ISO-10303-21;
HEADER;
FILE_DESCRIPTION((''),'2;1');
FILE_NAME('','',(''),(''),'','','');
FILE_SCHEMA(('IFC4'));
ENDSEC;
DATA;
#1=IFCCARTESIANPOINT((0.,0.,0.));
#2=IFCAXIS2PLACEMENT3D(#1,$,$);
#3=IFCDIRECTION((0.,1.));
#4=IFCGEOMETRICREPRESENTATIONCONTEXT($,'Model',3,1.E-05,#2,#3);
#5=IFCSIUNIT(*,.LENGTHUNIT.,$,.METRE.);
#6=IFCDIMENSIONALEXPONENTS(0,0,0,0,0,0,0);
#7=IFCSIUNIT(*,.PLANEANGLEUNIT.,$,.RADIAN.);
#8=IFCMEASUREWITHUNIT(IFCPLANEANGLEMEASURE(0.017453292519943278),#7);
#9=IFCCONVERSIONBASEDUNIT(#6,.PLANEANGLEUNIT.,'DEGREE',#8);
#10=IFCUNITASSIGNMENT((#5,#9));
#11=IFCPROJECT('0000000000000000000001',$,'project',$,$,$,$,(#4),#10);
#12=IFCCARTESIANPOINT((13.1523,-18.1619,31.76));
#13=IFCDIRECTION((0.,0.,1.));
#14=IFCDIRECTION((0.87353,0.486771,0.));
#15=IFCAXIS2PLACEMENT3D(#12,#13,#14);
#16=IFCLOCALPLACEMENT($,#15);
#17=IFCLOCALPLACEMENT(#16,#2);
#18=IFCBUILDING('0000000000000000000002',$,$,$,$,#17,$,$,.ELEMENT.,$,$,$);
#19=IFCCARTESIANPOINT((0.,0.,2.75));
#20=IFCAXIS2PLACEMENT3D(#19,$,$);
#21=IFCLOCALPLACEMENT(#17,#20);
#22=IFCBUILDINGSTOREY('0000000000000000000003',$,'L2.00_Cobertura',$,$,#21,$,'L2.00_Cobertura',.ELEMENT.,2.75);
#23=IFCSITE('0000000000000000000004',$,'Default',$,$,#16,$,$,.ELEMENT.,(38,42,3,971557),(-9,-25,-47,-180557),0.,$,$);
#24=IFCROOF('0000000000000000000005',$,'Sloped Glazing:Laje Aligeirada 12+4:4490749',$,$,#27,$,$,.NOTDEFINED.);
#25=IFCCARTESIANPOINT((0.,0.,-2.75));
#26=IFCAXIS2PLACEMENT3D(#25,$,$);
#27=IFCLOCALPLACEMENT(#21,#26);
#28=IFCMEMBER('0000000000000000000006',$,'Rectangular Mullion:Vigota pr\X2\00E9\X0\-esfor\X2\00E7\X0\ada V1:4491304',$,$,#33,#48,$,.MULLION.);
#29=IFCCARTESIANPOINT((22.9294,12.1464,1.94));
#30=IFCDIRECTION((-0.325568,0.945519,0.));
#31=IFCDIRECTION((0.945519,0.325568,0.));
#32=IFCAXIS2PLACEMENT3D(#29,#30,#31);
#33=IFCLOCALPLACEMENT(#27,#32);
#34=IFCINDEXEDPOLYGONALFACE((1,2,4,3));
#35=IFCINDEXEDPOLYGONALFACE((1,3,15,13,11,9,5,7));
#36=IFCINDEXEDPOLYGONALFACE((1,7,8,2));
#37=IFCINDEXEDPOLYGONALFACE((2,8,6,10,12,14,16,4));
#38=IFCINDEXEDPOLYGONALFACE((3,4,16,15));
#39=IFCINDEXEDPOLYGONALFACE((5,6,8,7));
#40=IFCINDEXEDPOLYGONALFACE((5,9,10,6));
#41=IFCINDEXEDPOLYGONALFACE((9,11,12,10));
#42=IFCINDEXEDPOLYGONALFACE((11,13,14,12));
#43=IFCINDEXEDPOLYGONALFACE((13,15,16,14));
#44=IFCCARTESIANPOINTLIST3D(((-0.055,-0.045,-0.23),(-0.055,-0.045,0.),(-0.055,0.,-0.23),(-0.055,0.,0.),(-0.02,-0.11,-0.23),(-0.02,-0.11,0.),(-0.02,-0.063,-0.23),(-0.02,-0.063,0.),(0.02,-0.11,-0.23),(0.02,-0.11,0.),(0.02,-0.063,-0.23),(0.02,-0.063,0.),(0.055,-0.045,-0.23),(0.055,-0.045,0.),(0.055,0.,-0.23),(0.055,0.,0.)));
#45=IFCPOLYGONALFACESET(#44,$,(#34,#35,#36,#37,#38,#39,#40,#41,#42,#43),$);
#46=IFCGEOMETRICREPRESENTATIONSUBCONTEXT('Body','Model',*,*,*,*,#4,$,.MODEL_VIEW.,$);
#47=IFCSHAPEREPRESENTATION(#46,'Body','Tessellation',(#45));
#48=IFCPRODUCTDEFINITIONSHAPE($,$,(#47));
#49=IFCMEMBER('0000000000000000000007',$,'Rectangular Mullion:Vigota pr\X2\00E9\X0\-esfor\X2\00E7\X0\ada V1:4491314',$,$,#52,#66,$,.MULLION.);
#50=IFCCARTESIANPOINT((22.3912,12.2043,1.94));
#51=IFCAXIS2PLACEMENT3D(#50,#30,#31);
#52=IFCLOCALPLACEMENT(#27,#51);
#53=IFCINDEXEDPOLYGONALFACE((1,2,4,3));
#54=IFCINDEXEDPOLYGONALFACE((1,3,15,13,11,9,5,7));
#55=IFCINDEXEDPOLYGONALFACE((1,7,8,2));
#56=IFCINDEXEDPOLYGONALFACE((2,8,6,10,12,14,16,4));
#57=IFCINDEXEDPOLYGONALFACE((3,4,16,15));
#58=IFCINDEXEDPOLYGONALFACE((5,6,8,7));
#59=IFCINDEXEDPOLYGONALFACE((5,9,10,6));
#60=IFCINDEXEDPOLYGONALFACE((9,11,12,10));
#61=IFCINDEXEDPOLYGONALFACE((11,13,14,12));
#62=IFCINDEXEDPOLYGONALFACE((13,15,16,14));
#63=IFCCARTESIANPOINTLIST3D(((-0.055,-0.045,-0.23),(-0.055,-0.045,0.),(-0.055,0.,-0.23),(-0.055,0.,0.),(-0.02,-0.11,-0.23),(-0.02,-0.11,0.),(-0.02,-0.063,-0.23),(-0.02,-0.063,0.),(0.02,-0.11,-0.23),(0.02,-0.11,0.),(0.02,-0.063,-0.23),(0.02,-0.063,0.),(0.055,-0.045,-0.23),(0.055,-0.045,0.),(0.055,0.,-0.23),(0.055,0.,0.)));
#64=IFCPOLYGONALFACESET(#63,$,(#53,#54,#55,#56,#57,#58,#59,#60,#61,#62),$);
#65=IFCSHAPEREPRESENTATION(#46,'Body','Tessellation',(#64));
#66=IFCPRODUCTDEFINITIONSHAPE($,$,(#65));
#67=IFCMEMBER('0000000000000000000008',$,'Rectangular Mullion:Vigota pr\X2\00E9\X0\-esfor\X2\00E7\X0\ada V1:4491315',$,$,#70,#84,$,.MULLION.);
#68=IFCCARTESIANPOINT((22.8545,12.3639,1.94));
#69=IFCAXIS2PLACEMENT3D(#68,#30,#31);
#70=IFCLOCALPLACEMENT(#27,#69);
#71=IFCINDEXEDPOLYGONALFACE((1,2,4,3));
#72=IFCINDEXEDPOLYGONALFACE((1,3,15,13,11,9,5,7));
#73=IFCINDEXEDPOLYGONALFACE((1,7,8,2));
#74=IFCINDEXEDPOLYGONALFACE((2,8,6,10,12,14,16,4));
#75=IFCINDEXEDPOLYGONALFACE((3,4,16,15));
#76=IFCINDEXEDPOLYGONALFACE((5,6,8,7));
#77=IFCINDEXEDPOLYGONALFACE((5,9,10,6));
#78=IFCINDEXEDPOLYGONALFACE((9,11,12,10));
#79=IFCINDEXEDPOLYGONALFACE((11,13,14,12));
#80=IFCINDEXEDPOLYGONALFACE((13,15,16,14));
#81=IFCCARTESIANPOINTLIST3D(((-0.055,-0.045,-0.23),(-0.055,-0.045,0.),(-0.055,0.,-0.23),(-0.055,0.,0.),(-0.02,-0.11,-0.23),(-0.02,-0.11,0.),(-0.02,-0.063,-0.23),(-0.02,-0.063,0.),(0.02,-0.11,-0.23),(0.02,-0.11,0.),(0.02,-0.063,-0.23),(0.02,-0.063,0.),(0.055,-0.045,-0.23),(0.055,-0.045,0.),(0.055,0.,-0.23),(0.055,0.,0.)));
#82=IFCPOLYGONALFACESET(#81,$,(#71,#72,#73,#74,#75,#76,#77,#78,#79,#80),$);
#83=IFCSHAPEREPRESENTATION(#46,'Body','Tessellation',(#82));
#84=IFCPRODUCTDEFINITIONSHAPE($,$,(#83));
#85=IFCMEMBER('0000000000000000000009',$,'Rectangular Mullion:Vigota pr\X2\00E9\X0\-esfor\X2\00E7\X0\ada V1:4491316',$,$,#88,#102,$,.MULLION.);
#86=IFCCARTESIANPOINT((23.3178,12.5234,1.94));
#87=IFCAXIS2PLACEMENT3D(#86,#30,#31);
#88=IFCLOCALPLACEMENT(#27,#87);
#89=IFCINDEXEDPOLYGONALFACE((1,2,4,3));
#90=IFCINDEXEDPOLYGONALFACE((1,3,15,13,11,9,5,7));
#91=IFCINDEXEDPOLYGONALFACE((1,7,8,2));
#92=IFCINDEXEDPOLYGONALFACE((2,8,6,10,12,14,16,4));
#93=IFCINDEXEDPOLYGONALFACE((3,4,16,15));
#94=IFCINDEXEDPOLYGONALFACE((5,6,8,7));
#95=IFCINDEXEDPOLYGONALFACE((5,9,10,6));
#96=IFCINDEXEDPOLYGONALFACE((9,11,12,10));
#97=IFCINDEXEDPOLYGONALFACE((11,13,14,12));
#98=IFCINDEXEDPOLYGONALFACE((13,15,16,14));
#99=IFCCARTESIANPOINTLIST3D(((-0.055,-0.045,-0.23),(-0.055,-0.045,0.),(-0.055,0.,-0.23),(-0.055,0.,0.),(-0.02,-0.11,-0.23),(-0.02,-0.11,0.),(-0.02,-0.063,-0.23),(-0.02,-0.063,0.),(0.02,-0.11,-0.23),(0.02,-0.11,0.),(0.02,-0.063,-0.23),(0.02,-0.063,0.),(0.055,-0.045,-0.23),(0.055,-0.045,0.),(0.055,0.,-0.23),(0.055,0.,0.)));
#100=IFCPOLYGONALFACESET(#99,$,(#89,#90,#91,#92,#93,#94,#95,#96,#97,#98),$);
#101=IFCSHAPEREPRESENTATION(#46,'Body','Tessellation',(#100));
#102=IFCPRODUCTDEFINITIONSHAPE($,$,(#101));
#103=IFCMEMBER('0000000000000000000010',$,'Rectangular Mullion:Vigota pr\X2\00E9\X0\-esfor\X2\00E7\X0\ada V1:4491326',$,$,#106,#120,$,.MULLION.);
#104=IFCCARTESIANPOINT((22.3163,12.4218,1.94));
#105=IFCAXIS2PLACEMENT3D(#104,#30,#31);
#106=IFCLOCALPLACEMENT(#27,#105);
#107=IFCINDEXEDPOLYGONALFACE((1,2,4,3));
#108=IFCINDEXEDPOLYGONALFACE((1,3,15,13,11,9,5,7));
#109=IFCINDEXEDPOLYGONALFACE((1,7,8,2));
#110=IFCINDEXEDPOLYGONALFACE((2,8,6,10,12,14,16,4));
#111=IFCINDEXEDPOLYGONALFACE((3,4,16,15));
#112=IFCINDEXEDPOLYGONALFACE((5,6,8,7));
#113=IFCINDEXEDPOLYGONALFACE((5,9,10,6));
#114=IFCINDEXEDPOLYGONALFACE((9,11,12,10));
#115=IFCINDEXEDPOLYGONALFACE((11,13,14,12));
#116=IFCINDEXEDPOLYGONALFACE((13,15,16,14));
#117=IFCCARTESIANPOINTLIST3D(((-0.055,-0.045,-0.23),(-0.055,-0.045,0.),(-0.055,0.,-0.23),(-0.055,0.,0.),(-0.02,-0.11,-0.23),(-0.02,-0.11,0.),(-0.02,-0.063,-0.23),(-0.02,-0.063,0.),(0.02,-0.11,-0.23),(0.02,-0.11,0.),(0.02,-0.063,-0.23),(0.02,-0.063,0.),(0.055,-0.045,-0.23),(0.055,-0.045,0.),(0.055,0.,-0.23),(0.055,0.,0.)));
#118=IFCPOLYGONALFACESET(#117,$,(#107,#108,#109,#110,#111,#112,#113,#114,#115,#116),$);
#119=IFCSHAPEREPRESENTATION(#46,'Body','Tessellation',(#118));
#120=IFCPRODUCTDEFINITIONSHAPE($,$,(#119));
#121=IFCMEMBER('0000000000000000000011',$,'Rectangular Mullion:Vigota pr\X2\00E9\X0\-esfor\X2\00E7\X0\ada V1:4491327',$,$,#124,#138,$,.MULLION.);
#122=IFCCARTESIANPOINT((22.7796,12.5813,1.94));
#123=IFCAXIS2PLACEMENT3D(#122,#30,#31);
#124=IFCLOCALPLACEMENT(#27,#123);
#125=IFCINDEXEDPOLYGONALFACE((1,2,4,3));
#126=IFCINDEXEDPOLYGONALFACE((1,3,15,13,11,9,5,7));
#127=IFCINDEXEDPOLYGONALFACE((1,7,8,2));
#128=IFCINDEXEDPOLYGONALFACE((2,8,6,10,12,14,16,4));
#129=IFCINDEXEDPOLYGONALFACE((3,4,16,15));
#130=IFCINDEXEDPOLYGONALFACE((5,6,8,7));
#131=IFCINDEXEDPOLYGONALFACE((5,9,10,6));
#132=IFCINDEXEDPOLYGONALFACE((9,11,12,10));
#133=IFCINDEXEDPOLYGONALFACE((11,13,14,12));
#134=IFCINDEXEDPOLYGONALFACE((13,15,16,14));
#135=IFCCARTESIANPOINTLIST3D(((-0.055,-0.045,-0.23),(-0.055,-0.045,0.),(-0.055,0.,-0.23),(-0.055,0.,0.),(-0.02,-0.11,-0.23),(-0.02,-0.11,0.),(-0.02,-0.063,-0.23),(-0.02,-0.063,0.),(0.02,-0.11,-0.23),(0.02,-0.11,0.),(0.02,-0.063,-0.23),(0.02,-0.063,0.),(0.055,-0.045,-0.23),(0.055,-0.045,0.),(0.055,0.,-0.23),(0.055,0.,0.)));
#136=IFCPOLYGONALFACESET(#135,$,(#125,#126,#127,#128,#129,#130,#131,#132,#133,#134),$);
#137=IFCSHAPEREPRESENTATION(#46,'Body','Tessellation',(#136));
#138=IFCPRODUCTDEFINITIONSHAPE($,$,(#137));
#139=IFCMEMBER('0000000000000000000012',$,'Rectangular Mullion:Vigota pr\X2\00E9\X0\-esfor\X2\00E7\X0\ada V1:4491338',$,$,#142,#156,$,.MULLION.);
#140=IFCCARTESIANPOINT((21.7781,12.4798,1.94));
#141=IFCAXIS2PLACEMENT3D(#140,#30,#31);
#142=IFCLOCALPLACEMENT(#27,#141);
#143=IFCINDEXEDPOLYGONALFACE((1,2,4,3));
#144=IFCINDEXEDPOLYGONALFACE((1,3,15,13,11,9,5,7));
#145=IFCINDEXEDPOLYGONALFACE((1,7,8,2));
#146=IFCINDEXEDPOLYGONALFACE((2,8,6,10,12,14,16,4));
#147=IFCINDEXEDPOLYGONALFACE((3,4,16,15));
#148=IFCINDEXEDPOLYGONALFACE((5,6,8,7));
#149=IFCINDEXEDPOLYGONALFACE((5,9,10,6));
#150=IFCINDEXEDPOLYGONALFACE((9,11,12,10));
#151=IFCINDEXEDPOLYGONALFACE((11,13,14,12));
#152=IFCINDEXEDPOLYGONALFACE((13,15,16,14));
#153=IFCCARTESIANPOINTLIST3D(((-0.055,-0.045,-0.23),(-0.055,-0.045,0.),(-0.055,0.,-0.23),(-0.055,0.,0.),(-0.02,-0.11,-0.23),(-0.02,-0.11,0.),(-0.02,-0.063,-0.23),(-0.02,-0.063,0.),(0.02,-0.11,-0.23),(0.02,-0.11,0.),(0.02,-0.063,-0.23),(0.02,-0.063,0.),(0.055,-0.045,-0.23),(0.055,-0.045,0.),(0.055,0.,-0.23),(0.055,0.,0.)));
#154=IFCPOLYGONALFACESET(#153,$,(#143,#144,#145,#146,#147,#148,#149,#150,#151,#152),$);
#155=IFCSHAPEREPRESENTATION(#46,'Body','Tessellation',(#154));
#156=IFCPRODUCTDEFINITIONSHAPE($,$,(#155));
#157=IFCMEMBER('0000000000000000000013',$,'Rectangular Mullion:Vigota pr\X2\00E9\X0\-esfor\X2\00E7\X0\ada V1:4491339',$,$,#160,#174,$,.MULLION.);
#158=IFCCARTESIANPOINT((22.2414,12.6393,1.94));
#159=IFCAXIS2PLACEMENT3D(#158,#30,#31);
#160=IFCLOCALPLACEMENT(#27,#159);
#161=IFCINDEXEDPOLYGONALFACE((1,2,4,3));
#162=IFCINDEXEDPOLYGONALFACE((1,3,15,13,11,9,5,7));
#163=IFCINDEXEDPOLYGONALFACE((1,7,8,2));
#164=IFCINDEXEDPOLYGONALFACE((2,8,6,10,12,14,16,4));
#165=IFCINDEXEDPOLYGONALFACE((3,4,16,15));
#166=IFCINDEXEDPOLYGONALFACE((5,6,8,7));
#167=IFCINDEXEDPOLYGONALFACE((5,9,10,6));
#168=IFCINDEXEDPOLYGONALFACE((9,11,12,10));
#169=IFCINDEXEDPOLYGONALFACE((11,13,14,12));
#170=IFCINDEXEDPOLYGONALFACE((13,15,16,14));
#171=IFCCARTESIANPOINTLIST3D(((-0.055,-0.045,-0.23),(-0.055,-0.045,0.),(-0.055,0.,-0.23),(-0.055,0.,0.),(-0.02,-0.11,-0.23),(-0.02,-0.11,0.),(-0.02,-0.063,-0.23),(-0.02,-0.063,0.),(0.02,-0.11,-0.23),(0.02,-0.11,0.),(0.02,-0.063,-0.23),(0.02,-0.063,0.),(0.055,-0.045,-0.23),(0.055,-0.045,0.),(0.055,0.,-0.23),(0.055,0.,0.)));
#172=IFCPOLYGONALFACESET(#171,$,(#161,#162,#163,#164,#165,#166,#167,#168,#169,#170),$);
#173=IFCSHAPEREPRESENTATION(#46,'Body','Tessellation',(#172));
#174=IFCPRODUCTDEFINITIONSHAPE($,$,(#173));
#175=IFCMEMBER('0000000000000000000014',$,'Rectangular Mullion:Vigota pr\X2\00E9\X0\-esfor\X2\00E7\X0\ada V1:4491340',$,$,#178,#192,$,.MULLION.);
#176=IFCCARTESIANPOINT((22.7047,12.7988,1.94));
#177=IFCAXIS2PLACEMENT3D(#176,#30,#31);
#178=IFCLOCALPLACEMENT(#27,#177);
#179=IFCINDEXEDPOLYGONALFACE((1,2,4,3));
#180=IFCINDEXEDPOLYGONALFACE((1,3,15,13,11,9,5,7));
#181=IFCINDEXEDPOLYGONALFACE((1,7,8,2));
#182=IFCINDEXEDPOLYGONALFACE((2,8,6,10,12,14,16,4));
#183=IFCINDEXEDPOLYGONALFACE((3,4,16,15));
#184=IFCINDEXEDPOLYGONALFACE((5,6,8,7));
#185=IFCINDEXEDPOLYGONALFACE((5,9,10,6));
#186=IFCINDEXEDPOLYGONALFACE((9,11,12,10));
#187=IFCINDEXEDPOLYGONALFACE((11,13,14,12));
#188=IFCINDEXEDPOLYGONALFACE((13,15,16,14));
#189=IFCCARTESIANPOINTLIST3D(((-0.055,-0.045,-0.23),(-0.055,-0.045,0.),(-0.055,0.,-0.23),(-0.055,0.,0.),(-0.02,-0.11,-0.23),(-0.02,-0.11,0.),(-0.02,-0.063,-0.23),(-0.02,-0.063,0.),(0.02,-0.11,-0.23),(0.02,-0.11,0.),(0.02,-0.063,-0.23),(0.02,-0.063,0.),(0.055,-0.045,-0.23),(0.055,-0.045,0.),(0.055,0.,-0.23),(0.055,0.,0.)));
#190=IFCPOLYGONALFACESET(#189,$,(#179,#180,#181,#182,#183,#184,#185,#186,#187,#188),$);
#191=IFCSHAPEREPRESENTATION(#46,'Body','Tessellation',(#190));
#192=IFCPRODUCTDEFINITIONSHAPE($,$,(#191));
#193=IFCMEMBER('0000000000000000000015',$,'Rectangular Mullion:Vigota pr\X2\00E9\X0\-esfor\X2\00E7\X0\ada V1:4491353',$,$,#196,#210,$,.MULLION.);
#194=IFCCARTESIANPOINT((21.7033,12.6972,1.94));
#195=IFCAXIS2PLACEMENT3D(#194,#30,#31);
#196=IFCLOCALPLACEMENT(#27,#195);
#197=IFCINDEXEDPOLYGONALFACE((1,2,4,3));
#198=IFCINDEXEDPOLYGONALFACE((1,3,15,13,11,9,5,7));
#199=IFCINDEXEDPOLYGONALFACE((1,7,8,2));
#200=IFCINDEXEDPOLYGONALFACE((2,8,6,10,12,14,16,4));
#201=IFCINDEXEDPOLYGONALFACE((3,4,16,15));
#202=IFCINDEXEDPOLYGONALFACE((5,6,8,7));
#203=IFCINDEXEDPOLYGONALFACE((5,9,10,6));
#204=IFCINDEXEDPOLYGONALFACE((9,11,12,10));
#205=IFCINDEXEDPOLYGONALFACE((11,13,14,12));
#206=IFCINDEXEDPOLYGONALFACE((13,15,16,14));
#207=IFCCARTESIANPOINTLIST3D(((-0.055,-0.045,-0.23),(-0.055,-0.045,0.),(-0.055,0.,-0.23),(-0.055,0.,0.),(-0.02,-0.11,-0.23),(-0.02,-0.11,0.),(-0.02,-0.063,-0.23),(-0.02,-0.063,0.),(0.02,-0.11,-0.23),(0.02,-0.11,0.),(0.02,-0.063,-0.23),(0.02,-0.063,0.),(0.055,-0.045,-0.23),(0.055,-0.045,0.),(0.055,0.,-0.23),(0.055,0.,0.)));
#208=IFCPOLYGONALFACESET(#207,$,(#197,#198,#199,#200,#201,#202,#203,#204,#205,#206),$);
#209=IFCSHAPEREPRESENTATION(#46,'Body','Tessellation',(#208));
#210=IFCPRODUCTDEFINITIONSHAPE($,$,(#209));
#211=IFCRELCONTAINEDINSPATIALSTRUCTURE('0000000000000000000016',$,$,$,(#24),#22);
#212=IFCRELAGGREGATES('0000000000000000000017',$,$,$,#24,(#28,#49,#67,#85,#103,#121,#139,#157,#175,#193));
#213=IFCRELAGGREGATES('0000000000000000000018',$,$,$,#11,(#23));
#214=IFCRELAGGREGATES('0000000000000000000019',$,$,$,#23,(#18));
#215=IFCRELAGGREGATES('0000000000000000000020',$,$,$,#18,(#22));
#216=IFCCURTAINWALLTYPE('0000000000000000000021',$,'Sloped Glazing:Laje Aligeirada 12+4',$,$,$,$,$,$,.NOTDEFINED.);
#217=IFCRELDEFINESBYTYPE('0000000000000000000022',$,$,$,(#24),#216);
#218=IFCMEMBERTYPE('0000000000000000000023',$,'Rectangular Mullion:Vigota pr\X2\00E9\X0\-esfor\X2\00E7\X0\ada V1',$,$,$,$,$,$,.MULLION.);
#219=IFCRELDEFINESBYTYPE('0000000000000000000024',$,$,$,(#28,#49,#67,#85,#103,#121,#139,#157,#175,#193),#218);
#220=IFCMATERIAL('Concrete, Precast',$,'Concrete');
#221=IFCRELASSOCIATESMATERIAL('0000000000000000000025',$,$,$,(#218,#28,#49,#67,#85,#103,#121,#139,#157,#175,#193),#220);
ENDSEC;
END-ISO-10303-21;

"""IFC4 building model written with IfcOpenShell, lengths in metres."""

from ifc_helpers import new_model, entity, si_unit, converted_unit, direction, frame, origin, place, context, subcontext, project, spatial, indexed_curve, outline, extrude, source, transform, mapped, material, type_object, type_shapes, element, aggregate, save


model = new_model("IFC4")

# Units and contexts
model_context = context("Model", 3, precision=1e-05, world=origin(), true_north=direction((0.0, 1.0)))
body_context = subcontext(model_context, "Body", "Model", "MODEL_VIEW")
ifc_project = project(units=[si_unit("LENGTHUNIT", "METRE"), converted_unit("PLANEANGLEUNIT", "DEGREE", entity("IfcPlaneAngleMeasure", 0.017453292519943278), si_unit("PLANEANGLEUNIT", "RADIAN"), dimensions=[0, 0, 0, 0, 0, 0, 0])], contexts=[model_context])

# Site, building, storey
site_placement = place(None, frame((13.1523, -18.1619, 31.76), z_axis=(0.0, 0.0, 1.0), x_axis=(0.87353, 0.486771, 0.0)))
site = spatial("IfcSite", under=ifc_project, at=site_placement, Name="Default", CompositionType="ELEMENT", RefLatitude=(38, 42, 3, 971557), RefLongitude=(-9, -25, -47, -180557), RefElevation=0.0)
building_placement = place(site_placement, origin())
building = spatial("IfcBuilding", under=site, at=building_placement, CompositionType="ELEMENT")
storey_placement = place(building_placement, frame((0.0, 0.0, 2.75)))
storey = spatial("IfcBuildingStorey", under=building, at=storey_placement, Name="L2.00_Cobertura", LongName="L2.00_Cobertura", CompositionType="ELEMENT", Elevation=2.75)

# Roof, members
curtain_wall_type = type_object("IfcCurtainWallType", Name="Sloped Glazing:Laje Aligeirada 12+4", PredefinedType="NOTDEFINED")
roof_placement = place(storey_placement, frame((0.0, 0.0, -2.75)))
roof = element("IfcRoof", 1, at=roof_placement, inside=storey, type_object=curtain_wall_type, Name="Sloped Glazing:Laje Aligeirada 12+4:4490749", PredefinedType="NOTDEFINED")
ifc_material_1 = material(Name="Concrete, Precast", Category="Concrete")
member_type = type_object("IfcMemberType", Name="Rectangular Mullion:Vigota pré-esforçada V1", PredefinedType="MULLION", material=ifc_material_1)
shared_shape_1 = source(origin(), body_context, "Body", "SweptSolid", [
    extrude(outline(indexed_curve([(-0.055, -0.0545), (0.055, -0.0545), (0.055, -0.0095), (0.02, 0.0085), (0.02, 0.0555), (-0.02, 0.0555), (-0.02, 0.0085), (-0.055, -0.0095), (-0.055, -0.0545)], self_intersect=False)), frame((0.0, -0.0545, -0.23), z_axis=(0.0, 0.0, 1.0), x_axis=(-1.0, 0.0, 0.0)), (0.0, 0.0, 1.0), 0.23),
])
type_shapes(member_type, [shared_shape_1])
member_1_placement = place(roof_placement, frame((22.9294, 12.1464, 1.94), z_axis=(-0.325568, 0.945519, 0.0), x_axis=(0.945519, 0.325568, 0.0)))
member_1 = element("IfcMember", 2, at=member_1_placement, type_object=member_type, material=ifc_material_1, Name="Rectangular Mullion:Vigota pré-esforçada V1:4491304", PredefinedType="MULLION", context=body_context, shape_type="MappedRepresentation", body=[
    mapped(shared_shape_1, transform((0.0, 0.0, 0.0), scale=1.0)),
])
member_2_placement = place(roof_placement, frame((22.3912, 12.2043, 1.94), z_axis=(-0.325568, 0.945519, 0.0), x_axis=(0.945519, 0.325568, 0.0)))
member_2 = element("IfcMember", 3, at=member_2_placement, type_object=member_type, material=ifc_material_1, Name="Rectangular Mullion:Vigota pré-esforçada V1:4491314", PredefinedType="MULLION", context=body_context, shape_type="MappedRepresentation", body=[
    mapped(shared_shape_1, transform((0.0, 0.0, 0.0), scale=1.0)),
])
member_3_placement = place(roof_placement, frame((22.8545, 12.3639, 1.94), z_axis=(-0.325568, 0.945519, 0.0), x_axis=(0.945519, 0.325568, 0.0)))
member_3 = element("IfcMember", 4, at=member_3_placement, type_object=member_type, material=ifc_material_1, Name="Rectangular Mullion:Vigota pré-esforçada V1:4491315", PredefinedType="MULLION", context=body_context, shape_type="MappedRepresentation", body=[
    mapped(shared_shape_1, transform((0.0, 0.0, 0.0), scale=1.0)),
])
member_4_placement = place(roof_placement, frame((23.3178, 12.5234, 1.94), z_axis=(-0.325568, 0.945519, 0.0), x_axis=(0.945519, 0.325568, 0.0)))
member_4 = element("IfcMember", 5, at=member_4_placement, type_object=member_type, material=ifc_material_1, Name="Rectangular Mullion:Vigota pré-esforçada V1:4491316", PredefinedType="MULLION", context=body_context, shape_type="MappedRepresentation", body=[
    mapped(shared_shape_1, transform((0.0, 0.0, 0.0), scale=1.0)),
])
member_5_placement = place(roof_placement, frame((22.3163, 12.4218, 1.94), z_axis=(-0.325568, 0.945519, 0.0), x_axis=(0.945519, 0.325568, 0.0)))
member_5 = element("IfcMember", 6, at=member_5_placement, type_object=member_type, material=ifc_material_1, Name="Rectangular Mullion:Vigota pré-esforçada V1:4491326", PredefinedType="MULLION", context=body_context, shape_type="MappedRepresentation", body=[
    mapped(shared_shape_1, transform((0.0, 0.0, 0.0), scale=1.0)),
])
member_6_placement = place(roof_placement, frame((22.7796, 12.5813, 1.94), z_axis=(-0.325568, 0.945519, 0.0), x_axis=(0.945519, 0.325568, 0.0)))
member_6 = element("IfcMember", 7, at=member_6_placement, type_object=member_type, material=ifc_material_1, Name="Rectangular Mullion:Vigota pré-esforçada V1:4491327", PredefinedType="MULLION", context=body_context, shape_type="MappedRepresentation", body=[
    mapped(shared_shape_1, transform((0.0, 0.0, 0.0), scale=1.0)),
])
member_7_placement = place(roof_placement, frame((21.7781, 12.4798, 1.94), z_axis=(-0.325568, 0.945519, 0.0), x_axis=(0.945519, 0.325568, 0.0)))
member_7 = element("IfcMember", 8, at=member_7_placement, type_object=member_type, material=ifc_material_1, Name="Rectangular Mullion:Vigota pré-esforçada V1:4491338", PredefinedType="MULLION", context=body_context, shape_type="MappedRepresentation", body=[
    mapped(shared_shape_1, transform((0.0, 0.0, 0.0), scale=1.0)),
])
member_8_placement = place(roof_placement, frame((22.2414, 12.6393, 1.94), z_axis=(-0.325568, 0.945519, 0.0), x_axis=(0.945519, 0.325568, 0.0)))
member_8 = element("IfcMember", 9, at=member_8_placement, type_object=member_type, material=ifc_material_1, Name="Rectangular Mullion:Vigota pré-esforçada V1:4491339", PredefinedType="MULLION", context=body_context, shape_type="MappedRepresentation", body=[
    mapped(shared_shape_1, transform((0.0, 0.0, 0.0), scale=1.0)),
])
member_9_placement = place(roof_placement, frame((22.7047, 12.7988, 1.94), z_axis=(-0.325568, 0.945519, 0.0), x_axis=(0.945519, 0.325568, 0.0)))
member_9 = element("IfcMember", 10, at=member_9_placement, type_object=member_type, material=ifc_material_1, Name="Rectangular Mullion:Vigota pré-esforçada V1:4491340", PredefinedType="MULLION", context=body_context, shape_type="MappedRepresentation", body=[
    mapped(shared_shape_1, transform((0.0, 0.0, 0.0), scale=1.0)),
])
member_10_placement = place(roof_placement, frame((21.7033, 12.6972, 1.94), z_axis=(-0.325568, 0.945519, 0.0), x_axis=(0.945519, 0.325568, 0.0)))
member_10 = element("IfcMember", 11, at=member_10_placement, type_object=member_type, material=ifc_material_1, Name="Rectangular Mullion:Vigota pré-esforçada V1:4491353", PredefinedType="MULLION", context=body_context, shape_type="MappedRepresentation", body=[
    mapped(shared_shape_1, transform((0.0, 0.0, 0.0), scale=1.0)),
])
aggregate(roof, [member_1, member_2, member_3, member_4, member_5, member_6, member_7, member_8, member_9, member_10])

save(model, "model.ifc")
